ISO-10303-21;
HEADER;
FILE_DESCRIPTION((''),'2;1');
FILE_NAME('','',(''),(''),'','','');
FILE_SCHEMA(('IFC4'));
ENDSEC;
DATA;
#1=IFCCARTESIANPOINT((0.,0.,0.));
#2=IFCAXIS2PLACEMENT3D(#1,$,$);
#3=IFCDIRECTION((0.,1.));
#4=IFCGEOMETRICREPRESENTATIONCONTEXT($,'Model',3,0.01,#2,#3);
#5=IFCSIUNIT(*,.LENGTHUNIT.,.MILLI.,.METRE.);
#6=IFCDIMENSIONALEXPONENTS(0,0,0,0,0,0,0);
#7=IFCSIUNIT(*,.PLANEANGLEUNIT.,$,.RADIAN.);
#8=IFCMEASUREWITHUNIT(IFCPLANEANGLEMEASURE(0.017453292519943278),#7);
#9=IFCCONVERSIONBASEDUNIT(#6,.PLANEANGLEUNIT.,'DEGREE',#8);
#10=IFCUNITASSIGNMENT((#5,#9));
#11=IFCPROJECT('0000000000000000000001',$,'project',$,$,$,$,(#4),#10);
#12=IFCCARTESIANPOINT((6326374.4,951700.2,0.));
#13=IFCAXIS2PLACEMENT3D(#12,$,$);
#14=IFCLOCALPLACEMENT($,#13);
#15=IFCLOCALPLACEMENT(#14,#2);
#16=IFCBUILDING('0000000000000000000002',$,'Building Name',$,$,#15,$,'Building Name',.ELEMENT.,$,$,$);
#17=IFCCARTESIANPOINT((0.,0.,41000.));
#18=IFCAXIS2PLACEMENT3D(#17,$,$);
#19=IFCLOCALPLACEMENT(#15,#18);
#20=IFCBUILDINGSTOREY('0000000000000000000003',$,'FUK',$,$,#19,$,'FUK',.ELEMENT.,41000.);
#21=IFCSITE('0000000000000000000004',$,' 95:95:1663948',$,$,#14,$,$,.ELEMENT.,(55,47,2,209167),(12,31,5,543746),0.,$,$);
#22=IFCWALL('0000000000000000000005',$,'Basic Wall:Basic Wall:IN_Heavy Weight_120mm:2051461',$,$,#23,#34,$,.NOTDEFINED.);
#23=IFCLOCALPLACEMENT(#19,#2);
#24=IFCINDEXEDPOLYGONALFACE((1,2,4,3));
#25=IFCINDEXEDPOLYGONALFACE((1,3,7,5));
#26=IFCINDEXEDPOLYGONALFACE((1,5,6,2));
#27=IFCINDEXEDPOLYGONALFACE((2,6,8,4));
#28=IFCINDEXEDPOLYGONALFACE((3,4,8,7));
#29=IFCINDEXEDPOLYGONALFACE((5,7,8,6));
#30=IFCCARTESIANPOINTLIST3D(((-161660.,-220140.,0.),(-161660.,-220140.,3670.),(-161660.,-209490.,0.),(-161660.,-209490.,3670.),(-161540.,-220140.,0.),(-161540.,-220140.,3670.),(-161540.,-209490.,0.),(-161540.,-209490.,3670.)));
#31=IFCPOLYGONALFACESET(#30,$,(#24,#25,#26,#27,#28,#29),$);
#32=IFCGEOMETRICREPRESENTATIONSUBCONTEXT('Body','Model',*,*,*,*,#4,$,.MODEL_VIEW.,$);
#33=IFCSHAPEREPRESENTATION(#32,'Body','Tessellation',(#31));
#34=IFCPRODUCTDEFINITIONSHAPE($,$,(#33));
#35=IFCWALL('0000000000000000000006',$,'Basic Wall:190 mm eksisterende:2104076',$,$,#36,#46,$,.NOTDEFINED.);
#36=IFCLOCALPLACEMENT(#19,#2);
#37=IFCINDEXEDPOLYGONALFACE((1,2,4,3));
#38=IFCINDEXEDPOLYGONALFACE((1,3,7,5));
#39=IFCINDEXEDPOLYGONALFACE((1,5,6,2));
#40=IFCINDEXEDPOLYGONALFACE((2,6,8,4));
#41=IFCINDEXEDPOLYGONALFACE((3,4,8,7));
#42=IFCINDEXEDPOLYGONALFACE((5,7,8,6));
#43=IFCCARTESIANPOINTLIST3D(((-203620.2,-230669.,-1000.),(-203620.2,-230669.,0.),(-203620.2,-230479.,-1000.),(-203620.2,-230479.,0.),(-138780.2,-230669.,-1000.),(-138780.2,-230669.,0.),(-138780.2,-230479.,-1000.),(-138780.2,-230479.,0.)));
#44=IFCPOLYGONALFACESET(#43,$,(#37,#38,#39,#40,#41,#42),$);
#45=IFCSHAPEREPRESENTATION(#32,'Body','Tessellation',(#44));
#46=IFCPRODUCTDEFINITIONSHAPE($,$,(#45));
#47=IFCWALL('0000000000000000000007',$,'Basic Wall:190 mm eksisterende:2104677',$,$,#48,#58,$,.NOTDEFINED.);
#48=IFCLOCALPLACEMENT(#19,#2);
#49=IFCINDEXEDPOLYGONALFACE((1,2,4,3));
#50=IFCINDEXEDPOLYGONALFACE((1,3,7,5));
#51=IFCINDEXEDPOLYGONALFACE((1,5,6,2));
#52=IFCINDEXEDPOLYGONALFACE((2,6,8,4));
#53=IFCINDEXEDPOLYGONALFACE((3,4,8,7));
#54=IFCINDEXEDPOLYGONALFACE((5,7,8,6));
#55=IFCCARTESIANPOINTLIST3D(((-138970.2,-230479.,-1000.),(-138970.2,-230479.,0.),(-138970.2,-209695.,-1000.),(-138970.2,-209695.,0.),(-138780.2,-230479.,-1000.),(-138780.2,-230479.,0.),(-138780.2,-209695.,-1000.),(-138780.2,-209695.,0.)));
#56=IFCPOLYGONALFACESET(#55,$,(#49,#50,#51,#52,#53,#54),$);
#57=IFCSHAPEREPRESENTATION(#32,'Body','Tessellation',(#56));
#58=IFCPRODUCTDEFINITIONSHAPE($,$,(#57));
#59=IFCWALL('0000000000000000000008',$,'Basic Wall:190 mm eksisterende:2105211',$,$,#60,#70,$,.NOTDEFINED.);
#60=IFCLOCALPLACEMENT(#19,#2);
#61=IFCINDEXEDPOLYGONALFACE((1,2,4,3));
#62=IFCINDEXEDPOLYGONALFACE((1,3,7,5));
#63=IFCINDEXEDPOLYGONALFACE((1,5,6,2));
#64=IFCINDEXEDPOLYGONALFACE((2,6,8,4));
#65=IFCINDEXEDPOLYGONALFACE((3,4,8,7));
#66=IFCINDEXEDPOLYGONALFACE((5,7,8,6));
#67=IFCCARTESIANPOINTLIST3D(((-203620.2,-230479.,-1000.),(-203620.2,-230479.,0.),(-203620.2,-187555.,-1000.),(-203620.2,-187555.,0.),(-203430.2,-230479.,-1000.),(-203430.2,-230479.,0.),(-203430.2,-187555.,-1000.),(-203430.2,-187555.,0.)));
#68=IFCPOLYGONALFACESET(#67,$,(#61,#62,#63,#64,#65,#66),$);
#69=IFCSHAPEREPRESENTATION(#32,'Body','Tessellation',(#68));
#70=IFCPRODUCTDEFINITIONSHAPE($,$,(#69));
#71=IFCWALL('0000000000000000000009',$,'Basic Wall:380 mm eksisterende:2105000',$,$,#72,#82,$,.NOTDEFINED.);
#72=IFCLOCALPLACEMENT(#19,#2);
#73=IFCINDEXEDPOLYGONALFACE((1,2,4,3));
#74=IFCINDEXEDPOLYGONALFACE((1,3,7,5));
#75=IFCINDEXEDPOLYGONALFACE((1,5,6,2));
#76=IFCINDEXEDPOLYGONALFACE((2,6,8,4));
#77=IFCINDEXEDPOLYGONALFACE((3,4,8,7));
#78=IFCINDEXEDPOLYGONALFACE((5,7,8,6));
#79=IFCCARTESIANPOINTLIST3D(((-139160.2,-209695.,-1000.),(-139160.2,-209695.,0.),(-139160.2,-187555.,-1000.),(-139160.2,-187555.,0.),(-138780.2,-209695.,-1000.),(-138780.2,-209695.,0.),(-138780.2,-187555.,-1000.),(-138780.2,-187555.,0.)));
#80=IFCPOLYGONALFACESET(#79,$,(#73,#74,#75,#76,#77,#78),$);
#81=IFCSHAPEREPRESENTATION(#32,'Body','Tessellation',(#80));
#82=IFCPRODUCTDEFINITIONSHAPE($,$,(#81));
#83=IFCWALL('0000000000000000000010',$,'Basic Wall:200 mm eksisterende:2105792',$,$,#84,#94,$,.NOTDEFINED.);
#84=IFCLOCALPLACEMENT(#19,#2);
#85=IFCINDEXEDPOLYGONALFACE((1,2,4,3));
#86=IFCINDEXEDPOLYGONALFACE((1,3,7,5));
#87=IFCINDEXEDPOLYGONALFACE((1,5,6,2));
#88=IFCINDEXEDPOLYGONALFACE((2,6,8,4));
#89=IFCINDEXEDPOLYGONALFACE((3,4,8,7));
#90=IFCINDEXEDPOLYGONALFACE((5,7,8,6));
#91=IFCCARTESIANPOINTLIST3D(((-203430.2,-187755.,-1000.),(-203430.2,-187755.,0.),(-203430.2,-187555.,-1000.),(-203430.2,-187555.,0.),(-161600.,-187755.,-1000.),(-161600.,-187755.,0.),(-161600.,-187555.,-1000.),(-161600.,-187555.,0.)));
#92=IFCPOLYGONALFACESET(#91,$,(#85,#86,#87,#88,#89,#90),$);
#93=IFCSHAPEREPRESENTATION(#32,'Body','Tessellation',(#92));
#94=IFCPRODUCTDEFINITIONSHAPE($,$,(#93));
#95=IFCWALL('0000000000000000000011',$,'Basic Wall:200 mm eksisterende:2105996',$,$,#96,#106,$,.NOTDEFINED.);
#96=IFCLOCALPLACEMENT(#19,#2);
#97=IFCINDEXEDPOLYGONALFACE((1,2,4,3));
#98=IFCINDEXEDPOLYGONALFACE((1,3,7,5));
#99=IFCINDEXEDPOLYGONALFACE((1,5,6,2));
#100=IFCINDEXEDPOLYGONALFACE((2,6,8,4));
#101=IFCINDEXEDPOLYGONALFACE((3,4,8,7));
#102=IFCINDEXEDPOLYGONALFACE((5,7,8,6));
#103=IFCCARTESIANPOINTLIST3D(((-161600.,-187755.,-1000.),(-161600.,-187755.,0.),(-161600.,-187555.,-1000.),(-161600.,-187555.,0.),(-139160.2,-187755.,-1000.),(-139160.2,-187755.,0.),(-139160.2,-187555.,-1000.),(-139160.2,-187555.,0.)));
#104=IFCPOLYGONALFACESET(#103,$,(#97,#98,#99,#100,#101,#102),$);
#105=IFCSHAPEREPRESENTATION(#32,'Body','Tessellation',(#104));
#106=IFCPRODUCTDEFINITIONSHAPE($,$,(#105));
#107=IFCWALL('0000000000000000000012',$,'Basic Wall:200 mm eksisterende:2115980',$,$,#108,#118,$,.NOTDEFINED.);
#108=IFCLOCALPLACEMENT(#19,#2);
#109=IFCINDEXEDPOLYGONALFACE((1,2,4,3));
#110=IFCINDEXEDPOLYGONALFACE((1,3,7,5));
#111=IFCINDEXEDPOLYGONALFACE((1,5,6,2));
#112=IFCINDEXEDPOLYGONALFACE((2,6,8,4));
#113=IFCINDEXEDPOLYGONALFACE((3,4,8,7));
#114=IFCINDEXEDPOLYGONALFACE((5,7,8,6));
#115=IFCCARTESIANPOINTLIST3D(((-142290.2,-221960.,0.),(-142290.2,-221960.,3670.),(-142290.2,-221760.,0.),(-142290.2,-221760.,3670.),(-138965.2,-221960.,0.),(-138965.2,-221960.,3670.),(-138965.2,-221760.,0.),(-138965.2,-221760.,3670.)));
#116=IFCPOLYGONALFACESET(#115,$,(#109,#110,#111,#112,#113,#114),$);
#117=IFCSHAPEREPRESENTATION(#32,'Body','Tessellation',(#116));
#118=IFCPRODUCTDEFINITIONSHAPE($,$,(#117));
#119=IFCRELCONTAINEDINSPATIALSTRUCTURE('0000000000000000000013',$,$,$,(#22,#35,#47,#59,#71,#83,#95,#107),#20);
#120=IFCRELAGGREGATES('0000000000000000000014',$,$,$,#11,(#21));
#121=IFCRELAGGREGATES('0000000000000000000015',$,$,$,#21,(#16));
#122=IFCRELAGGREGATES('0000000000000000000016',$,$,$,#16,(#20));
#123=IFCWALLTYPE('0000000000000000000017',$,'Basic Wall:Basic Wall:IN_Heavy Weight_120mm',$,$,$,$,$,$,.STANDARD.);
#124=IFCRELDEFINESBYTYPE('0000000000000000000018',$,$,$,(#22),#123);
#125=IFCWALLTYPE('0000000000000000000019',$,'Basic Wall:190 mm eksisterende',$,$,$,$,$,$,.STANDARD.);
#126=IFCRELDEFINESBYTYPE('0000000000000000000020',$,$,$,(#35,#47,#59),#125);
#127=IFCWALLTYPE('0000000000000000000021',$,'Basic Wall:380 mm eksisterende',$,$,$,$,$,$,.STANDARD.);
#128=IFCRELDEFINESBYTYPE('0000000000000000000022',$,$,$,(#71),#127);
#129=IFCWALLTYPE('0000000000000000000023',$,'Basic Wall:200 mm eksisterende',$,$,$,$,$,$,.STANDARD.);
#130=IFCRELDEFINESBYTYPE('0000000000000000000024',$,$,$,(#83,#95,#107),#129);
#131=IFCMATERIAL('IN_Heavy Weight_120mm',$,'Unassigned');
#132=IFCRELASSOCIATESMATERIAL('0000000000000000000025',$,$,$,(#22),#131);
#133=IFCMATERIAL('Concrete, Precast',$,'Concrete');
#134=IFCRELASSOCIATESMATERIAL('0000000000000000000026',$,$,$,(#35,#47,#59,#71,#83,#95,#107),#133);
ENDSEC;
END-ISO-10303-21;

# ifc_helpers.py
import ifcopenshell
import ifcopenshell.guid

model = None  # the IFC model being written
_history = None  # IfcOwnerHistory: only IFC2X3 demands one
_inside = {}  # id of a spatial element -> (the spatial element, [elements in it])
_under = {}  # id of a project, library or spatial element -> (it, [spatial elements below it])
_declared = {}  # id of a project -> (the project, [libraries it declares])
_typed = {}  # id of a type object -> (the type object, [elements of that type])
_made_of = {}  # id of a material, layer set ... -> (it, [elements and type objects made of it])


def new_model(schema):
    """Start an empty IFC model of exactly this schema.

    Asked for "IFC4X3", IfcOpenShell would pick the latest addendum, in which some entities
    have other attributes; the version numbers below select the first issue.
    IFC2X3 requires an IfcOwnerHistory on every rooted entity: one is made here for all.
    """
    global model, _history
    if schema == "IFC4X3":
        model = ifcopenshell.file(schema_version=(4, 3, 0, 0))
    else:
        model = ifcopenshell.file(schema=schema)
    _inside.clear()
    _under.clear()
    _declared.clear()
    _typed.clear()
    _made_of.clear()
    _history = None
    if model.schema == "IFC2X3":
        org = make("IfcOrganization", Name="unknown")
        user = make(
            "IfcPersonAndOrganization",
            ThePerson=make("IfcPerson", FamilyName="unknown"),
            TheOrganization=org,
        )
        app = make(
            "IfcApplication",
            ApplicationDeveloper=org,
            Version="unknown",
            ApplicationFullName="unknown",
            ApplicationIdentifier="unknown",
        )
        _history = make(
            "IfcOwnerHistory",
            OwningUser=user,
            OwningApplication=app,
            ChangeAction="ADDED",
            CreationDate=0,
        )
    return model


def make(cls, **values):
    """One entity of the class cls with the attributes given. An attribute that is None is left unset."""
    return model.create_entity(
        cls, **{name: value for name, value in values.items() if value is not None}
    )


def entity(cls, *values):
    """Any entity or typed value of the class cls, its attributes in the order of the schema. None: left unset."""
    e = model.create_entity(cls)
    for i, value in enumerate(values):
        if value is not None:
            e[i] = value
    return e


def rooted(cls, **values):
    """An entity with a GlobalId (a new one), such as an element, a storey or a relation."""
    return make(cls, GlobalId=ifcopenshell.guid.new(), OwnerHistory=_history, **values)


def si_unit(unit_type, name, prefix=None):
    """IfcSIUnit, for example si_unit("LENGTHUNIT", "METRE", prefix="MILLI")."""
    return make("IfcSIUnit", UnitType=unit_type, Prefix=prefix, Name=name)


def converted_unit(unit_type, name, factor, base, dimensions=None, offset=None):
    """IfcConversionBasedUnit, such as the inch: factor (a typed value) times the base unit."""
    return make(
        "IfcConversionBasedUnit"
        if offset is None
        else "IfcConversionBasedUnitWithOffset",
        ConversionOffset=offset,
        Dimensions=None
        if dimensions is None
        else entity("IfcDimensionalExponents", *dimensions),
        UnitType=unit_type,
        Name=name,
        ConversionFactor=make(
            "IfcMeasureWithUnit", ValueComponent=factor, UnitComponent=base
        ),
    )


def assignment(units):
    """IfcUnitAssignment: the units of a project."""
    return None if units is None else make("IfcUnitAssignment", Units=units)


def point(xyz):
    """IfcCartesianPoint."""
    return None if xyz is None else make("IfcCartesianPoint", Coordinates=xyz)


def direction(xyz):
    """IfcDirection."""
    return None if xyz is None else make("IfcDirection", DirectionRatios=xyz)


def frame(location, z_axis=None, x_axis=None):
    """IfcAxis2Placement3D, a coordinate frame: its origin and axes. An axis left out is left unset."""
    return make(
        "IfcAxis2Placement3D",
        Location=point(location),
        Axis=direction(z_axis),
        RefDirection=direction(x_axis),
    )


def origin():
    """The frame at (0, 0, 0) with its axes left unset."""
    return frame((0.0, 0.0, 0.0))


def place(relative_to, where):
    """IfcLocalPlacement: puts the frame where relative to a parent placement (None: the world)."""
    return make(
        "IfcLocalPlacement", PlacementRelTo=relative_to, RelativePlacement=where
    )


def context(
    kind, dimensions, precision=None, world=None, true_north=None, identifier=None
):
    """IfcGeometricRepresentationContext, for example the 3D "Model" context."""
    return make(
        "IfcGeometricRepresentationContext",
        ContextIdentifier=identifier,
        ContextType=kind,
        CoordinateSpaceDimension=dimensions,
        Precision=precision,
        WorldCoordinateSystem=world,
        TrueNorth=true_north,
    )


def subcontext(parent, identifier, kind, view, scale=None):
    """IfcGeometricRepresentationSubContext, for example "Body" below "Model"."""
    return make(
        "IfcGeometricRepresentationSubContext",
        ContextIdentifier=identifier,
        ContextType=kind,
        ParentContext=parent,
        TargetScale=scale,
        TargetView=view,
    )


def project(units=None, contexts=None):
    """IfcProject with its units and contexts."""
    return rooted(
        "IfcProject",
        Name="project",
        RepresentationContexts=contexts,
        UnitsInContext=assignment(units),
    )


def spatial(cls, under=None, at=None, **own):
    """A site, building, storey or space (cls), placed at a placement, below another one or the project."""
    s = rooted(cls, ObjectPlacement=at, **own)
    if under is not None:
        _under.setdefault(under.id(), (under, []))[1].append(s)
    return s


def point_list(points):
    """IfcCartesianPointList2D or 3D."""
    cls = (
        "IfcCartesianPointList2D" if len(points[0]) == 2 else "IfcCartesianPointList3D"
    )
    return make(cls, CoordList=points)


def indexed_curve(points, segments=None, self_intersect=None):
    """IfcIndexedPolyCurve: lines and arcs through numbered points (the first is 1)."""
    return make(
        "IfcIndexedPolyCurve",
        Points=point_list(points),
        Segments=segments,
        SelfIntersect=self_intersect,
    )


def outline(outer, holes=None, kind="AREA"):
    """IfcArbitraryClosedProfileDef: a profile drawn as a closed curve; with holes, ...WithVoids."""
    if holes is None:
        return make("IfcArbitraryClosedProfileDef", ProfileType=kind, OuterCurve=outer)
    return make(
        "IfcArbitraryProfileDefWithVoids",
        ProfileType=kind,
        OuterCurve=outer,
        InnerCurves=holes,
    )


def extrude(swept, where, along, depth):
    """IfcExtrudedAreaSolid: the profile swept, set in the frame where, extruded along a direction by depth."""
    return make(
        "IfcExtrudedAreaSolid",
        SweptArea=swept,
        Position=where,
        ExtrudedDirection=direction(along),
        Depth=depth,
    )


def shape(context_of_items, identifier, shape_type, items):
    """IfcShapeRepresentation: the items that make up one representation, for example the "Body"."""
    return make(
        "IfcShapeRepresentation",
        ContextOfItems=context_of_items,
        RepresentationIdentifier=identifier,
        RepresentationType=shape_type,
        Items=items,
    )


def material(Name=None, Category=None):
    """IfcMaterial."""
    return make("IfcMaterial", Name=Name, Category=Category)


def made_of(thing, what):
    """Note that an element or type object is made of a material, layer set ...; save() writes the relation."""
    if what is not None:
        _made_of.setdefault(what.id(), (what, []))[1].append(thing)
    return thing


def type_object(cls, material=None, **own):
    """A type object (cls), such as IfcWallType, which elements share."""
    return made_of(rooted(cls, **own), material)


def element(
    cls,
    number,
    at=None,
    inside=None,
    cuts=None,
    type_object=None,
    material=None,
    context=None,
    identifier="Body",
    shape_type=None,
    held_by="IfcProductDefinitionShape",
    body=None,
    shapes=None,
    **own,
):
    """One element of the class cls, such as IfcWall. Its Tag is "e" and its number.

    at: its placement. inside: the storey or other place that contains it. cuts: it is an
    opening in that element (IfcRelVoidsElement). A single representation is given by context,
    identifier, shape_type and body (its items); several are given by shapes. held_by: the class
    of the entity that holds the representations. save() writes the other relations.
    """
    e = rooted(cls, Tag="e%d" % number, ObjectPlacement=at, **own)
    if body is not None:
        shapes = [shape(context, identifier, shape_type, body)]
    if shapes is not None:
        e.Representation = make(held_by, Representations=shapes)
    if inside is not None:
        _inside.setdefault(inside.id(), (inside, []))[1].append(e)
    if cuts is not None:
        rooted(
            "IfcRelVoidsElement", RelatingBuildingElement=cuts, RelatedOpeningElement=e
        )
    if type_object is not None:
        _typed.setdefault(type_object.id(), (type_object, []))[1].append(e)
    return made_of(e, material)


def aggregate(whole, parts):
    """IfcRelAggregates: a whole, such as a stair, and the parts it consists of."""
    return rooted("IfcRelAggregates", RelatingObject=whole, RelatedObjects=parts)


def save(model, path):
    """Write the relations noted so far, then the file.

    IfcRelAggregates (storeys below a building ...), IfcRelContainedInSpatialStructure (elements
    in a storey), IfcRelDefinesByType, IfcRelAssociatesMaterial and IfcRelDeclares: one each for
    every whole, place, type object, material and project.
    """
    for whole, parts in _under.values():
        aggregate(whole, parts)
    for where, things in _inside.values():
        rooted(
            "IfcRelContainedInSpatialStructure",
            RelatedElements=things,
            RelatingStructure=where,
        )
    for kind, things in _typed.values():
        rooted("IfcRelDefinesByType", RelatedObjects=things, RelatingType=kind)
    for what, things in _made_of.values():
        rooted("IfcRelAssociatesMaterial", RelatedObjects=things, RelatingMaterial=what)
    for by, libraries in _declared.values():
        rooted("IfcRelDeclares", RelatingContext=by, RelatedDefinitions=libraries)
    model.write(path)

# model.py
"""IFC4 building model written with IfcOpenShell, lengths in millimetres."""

from ifc_helpers import new_model, entity, si_unit, converted_unit, direction, frame, origin, place, context, subcontext, project, spatial, indexed_curve, outline, extrude, material, type_object, element, save


model = new_model("IFC4")

# Units and contexts
model_context = context("Model", 3, precision=0.01, world=origin(), true_north=direction((0.0, 1.0)))
body_context = subcontext(model_context, "Body", "Model", "MODEL_VIEW")
ifc_project = project(units=[si_unit("LENGTHUNIT", "METRE", prefix="MILLI"), converted_unit("PLANEANGLEUNIT", "DEGREE", entity("IfcPlaneAngleMeasure", 0.017453292519943278), si_unit("PLANEANGLEUNIT", "RADIAN"), dimensions=[0, 0, 0, 0, 0, 0, 0])], contexts=[model_context])

# Site, building, storey
site_placement = place(None, frame((6326374.4, 951700.2, 0.0)))
site = spatial("IfcSite", under=ifc_project, at=site_placement, Name=" 95:95:1663948", CompositionType="ELEMENT", RefLatitude=(55, 47, 2, 209167), RefLongitude=(12, 31, 5, 543746), RefElevation=0.0)
building_placement = place(site_placement, origin())
building = spatial("IfcBuilding", under=site, at=building_placement, Name="Building Name", LongName="Building Name", CompositionType="ELEMENT")
storey_placement = place(building_placement, frame((0.0, 0.0, 41000.0)))
storey = spatial("IfcBuildingStorey", under=building, at=storey_placement, Name="FUK", LongName="FUK", CompositionType="ELEMENT", Elevation=41000.0)

# Walls
ifc_material_1 = material(Name="Concrete, Precast", Category="Concrete")
ifc_material_2 = material(Name="IN_Heavy Weight_120mm", Category="Unassigned")
wall_type_1 = type_object("IfcWallType", Name="Basic Wall:Basic Wall:IN_Heavy Weight_120mm", PredefinedType="STANDARD")
wall_1_placement = place(storey_placement, frame((-161600.0, -220140.0, 0.0), z_axis=(0.0, 0.0, 1.0), x_axis=(0.0, 1.0, 0.0)))
element("IfcWall", 1, at=wall_1_placement, inside=storey, type_object=wall_type_1, material=ifc_material_2, Name="Basic Wall:Basic Wall:IN_Heavy Weight_120mm:2051461", PredefinedType="NOTDEFINED", context=body_context, shape_type="SweptSolid", body=[
    extrude(outline(indexed_curve([(10650.0, 60.0), (0.0, 60.0), (0.0, -60.0), (10650.0, -60.0), (10650.0, 60.0)], self_intersect=False)), origin(), (0.0, 0.0, 1.0), 3670.0),
])
wall_type_2 = type_object("IfcWallType", Name="Basic Wall:190 mm eksisterende", PredefinedType="STANDARD")
wall_2_placement = place(storey_placement, frame((-203620.2, -230574.0, -1000.0)))
element("IfcWall", 2, at=wall_2_placement, inside=storey, type_object=wall_type_2, material=ifc_material_1, Name="Basic Wall:190 mm eksisterende:2104076", PredefinedType="NOTDEFINED", context=body_context, shape_type="SweptSolid", body=[
    extrude(outline(indexed_curve([(64840.0, 95.0), (0.0, 95.0), (0.0, -95.0), (64840.0, -95.0), (64840.0, 95.0)], self_intersect=False)), origin(), (0.0, 0.0, 1.0), 1000.0),
])
wall_3_placement = place(storey_placement, frame((-138875.2, -230479.0, -1000.0), z_axis=(0.0, 0.0, 1.0), x_axis=(0.0, 1.0, 0.0)))
element("IfcWall", 3, at=wall_3_placement, inside=storey, type_object=wall_type_2, material=ifc_material_1, Name="Basic Wall:190 mm eksisterende:2104677", PredefinedType="NOTDEFINED", context=body_context, shape_type="SweptSolid", body=[
    extrude(outline(indexed_curve([(20784.0, 95.0), (0.0, 95.0), (0.0, -95.0), (20784.0, -95.0), (20784.0, 95.0)], self_intersect=False)), origin(), (0.0, 0.0, 1.0), 1000.0),
])
wall_4_placement = place(storey_placement, frame((-203525.2, -230479.0, -1000.0), z_axis=(0.0, 0.0, 1.0), x_axis=(0.0, 1.0, 0.0)))
element("IfcWall", 4, at=wall_4_placement, inside=storey, type_object=wall_type_2, material=ifc_material_1, Name="Basic Wall:190 mm eksisterende:2105211", PredefinedType="NOTDEFINED", context=body_context, shape_type="SweptSolid", body=[
    extrude(outline(indexed_curve([(42924.0, 95.0), (0.0, 95.0), (0.0, -95.0), (42924.0, -95.0), (42924.0, 95.0)], self_intersect=False)), origin(), (0.0, 0.0, 1.0), 1000.0),
])
wall_type_3 = type_object("IfcWallType", Name="Basic Wall:380 mm eksisterende", PredefinedType="STANDARD")
wall_5_placement = place(storey_placement, frame((-138970.2, -209695.0, -1000.0), z_axis=(0.0, 0.0, 1.0), x_axis=(0.0, 1.0, 0.0)))
element("IfcWall", 5, at=wall_5_placement, inside=storey, type_object=wall_type_3, material=ifc_material_1, Name="Basic Wall:380 mm eksisterende:2105000", PredefinedType="NOTDEFINED", context=body_context, shape_type="SweptSolid", body=[
    extrude(outline(indexed_curve([(22140.0, 190.0), (0.0, 190.0), (0.0, -190.0), (22140.0, -190.0), (22140.0, 190.0)], self_intersect=False)), origin(), (0.0, 0.0, 1.0), 1000.0),
])
wall_type_4 = type_object("IfcWallType", Name="Basic Wall:200 mm eksisterende", PredefinedType="STANDARD")
wall_6_placement = place(storey_placement, frame((-203430.2, -187655.0, -1000.0)))
element("IfcWall", 6, at=wall_6_placement, inside=storey, type_object=wall_type_4, material=ifc_material_1, Name="Basic Wall:200 mm eksisterende:2105792", PredefinedType="NOTDEFINED", context=body_context, shape_type="SweptSolid", body=[
    extrude(outline(indexed_curve([(41830.2, 100.0), (0.0, 100.0), (0.0, -100.0), (41830.2, -100.0), (41830.2, 100.0)], self_intersect=False)), origin(), (0.0, 0.0, 1.0), 1000.0),
])
wall_7_placement = place(storey_placement, frame((-139160.2, -187655.0, -1000.0), z_axis=(0.0, 0.0, 1.0), x_axis=(-1.0, 0.0, 0.0)))
element("IfcWall", 7, at=wall_7_placement, inside=storey, type_object=wall_type_4, material=ifc_material_1, Name="Basic Wall:200 mm eksisterende:2105996", PredefinedType="NOTDEFINED", context=body_context, shape_type="SweptSolid", body=[
    extrude(outline(indexed_curve([(22439.8, 100.0), (0.0, 100.0), (0.0, -100.0), (22439.8, -100.0), (22439.8, 100.0)], self_intersect=False)), origin(), (0.0, 0.0, 1.0), 1000.0),
])
wall_8_placement = place(storey_placement, frame((-142290.2, -221860.0, 0.0)))
element("IfcWall", 8, at=wall_8_placement, inside=storey, type_object=wall_type_4, material=ifc_material_1, Name="Basic Wall:200 mm eksisterende:2115980", PredefinedType="NOTDEFINED", context=body_context, shape_type="SweptSolid", body=[
    extrude(outline(indexed_curve([(3325.0, 100.0), (0.0, 100.0), (0.0, -100.0), (3325.0, -100.0), (3325.0, 100.0)], self_intersect=False)), origin(), (0.0, 0.0, 1.0), 3670.0),
])

save(model, "model.ifc")
